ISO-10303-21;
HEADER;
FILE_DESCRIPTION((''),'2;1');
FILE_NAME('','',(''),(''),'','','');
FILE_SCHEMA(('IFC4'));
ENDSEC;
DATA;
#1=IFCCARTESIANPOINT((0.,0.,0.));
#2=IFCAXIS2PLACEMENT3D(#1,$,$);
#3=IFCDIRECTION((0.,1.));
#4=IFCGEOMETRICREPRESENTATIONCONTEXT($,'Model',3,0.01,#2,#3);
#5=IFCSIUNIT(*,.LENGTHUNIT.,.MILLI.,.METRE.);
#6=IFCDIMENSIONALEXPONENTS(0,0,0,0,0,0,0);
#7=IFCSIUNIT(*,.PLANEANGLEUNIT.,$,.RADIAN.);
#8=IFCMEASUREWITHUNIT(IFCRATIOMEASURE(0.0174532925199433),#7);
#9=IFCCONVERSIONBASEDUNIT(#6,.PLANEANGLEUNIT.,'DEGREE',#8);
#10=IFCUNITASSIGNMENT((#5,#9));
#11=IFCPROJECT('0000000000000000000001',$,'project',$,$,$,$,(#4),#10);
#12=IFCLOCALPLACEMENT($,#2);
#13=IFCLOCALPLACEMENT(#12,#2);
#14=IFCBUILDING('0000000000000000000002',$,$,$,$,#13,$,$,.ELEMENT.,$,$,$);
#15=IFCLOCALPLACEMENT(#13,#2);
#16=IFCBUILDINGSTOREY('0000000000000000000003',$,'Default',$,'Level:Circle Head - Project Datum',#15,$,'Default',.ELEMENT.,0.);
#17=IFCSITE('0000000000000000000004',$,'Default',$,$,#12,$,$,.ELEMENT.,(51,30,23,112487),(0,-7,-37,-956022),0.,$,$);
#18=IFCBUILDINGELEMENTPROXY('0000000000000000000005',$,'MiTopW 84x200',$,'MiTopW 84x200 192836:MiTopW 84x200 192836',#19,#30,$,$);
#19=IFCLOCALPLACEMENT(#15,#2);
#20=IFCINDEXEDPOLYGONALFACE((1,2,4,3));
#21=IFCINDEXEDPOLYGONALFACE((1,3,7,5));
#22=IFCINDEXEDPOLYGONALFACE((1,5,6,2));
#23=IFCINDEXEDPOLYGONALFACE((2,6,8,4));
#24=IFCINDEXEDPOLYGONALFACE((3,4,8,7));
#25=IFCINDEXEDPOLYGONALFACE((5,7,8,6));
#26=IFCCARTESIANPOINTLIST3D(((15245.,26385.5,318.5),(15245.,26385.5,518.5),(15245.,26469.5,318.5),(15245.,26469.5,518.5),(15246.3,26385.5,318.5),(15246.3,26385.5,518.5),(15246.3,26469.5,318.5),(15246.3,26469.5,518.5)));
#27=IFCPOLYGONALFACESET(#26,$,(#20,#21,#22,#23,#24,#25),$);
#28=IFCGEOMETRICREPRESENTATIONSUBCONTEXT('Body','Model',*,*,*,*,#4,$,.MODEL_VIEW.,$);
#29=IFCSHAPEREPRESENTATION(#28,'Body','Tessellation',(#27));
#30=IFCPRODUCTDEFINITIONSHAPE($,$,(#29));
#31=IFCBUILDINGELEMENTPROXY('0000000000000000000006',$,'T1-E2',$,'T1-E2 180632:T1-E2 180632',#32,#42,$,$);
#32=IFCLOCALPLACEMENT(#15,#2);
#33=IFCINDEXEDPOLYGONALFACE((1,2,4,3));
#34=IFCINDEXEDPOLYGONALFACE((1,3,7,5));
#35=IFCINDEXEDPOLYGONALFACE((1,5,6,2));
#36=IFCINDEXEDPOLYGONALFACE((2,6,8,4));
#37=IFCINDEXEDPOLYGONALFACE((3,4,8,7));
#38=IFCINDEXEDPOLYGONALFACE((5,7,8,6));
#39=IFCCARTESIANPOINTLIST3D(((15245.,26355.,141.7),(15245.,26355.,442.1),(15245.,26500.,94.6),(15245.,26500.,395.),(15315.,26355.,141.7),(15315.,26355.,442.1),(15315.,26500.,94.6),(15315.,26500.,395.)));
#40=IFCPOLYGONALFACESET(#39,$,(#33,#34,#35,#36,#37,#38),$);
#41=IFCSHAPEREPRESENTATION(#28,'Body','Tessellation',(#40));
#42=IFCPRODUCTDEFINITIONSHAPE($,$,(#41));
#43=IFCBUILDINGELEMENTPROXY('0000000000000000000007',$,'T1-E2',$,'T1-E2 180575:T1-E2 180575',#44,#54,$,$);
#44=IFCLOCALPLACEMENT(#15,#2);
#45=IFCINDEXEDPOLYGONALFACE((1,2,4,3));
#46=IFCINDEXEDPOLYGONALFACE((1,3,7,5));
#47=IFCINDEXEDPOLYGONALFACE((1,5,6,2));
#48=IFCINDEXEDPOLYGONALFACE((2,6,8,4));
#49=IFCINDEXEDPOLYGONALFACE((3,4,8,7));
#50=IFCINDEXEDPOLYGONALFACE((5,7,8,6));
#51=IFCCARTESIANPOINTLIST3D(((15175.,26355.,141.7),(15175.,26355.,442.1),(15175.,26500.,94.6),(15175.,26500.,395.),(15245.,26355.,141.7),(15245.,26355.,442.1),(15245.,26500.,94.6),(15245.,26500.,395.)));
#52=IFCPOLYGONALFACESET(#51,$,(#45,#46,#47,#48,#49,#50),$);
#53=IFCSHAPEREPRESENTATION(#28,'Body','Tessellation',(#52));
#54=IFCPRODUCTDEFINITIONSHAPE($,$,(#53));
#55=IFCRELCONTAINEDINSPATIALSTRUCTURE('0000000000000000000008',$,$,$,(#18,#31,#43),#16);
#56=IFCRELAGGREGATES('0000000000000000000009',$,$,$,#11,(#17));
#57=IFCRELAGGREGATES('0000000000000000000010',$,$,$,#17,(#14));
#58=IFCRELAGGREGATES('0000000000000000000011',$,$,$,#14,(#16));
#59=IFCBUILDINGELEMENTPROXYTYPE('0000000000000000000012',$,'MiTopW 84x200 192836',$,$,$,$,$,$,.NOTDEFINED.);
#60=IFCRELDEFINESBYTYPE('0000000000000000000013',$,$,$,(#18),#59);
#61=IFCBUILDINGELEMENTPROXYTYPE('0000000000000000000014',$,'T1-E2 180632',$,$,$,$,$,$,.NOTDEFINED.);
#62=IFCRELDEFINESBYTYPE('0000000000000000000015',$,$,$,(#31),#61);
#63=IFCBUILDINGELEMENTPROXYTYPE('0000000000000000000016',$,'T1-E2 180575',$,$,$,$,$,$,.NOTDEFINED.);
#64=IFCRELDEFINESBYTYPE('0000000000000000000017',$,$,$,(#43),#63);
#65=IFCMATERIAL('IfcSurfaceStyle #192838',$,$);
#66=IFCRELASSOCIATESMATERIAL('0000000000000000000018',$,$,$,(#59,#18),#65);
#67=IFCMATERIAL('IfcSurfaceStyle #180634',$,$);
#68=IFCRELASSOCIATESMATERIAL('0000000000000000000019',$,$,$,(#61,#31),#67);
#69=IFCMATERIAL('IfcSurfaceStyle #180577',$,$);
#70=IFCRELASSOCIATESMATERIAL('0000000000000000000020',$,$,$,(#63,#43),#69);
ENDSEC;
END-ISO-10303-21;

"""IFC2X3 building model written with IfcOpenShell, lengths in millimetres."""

from ifc_helpers import new_model, entity, si_unit, converted_unit, direction, frame, frame_2d, origin, place, context, subcontext, project, spatial, polyline, rectangle, outline, extrude, source, transform, mapped, material, type_object, type_shapes, element, save


model = new_model("IFC2X3")

# Units and contexts
model_context = context("Model", 3, precision=0.01, world=origin(), true_north=direction((0.0, 1.0)))
body_context = subcontext(model_context, "Body", "Model", "MODEL_VIEW")
ifc_project = project(units=[si_unit("LENGTHUNIT", "METRE", prefix="MILLI"), converted_unit("PLANEANGLEUNIT", "DEGREE", entity("IfcRatioMeasure", 0.0174532925199433), si_unit("PLANEANGLEUNIT", "RADIAN"), dimensions=[0, 0, 0, 0, 0, 0, 0])], contexts=[model_context])

# Site, building, storey
site_placement = place(None, origin())
site = spatial("IfcSite", under=ifc_project, at=site_placement, Name="Default", CompositionType="ELEMENT", RefLatitude=(51, 30, 23, 112487), RefLongitude=(0, -7, -37, -956022), RefElevation=0.0)
building_placement = place(site_placement, origin())
building = spatial("IfcBuilding", under=site, at=building_placement, CompositionType="ELEMENT")
storey_placement = place(building_placement, origin())
storey = spatial("IfcBuildingStorey", under=building, at=storey_placement, Name="Default", ObjectType="Level:Circle Head - Project Datum", LongName="Default", CompositionType="ELEMENT", Elevation=0.0)

# Building element proxies
ifc_material_1 = material(Name="IfcSurfaceStyle #192838")
building_element_proxy_type_1 = type_object("IfcBuildingElementProxyType", Name="MiTopW 84x200 192836", PredefinedType="NOTDEFINED", material=ifc_material_1)
shared_shape_1 = source(origin(), body_context, "Body", "SweptSolid", [
    extrude(rectangle(XDim=200.0, YDim=84.0, at=frame_2d((0.0, 0.0), x_axis=(1.0, 0.0))), frame((100.0, 42.0, 0.0), z_axis=(0.0, 0.0, 1.0), x_axis=(-1.0, 0.0, 0.0)), (0.0, 0.0, 1.0), 1.3),
])
type_shapes(building_element_proxy_type_1, [shared_shape_1])
proxy_1_placement = place(building_placement, frame((15246.3, 26469.5, 518.5), z_axis=(-1.0, 0.0, 0.0), x_axis=(0.0, 0.0, -1.0)))
element("IfcBuildingElementProxy", 1, at=proxy_1_placement, inside=storey, type_object=building_element_proxy_type_1, material=ifc_material_1, Name="MiTopW 84x200", ObjectType="MiTopW 84x200 192836:MiTopW 84x200 192836", context=body_context, shape_type="MappedRepresentation", body=[
    mapped(shared_shape_1, transform((0.0, 0.0, 0.0), scale=1.0)),
])
ifc_material_2 = material(Name="IfcSurfaceStyle #180634")
building_element_proxy_type_2 = type_object("IfcBuildingElementProxyType", Name="T1-E2 180632", PredefinedType="NOTDEFINED", material=ifc_material_2)
shared_shape_2 = source(origin(), body_context, "Body", "SweptSolid", [
    extrude(outline(polyline([(-126.6, -72.5), (173.8, -72.5), (126.6, 72.5), (-173.8, 72.5), (-126.6, -72.5)])), frame((173.8, 72.5, 0.0), z_axis=(0.0, 0.0, 1.0), x_axis=(-1.0, 0.0, 0.0)), (0.0, 0.0, 1.0), 70.0),
])
type_shapes(building_element_proxy_type_2, [shared_shape_2])
proxy_2_placement = place(building_placement, frame((15315.0, 26500.0, 442.1), z_axis=(-1.0, 0.0, 0.0), x_axis=(0.0, 0.0, -1.0)))
element("IfcBuildingElementProxy", 2, at=proxy_2_placement, inside=storey, type_object=building_element_proxy_type_2, material=ifc_material_2, Name="T1-E2", ObjectType="T1-E2 180632:T1-E2 180632", context=body_context, shape_type="MappedRepresentation", body=[
    mapped(shared_shape_2, transform((0.0, 0.0, 0.0), scale=1.0)),
])
ifc_material_3 = material(Name="IfcSurfaceStyle #180577")
building_element_proxy_type_3 = type_object("IfcBuildingElementProxyType", Name="T1-E2 180575", PredefinedType="NOTDEFINED", material=ifc_material_3)
shared_shape_3 = source(origin(), body_context, "Body", "SweptSolid", [
    extrude(outline(polyline([(-126.6, -72.5), (173.8, -72.5), (126.6, 72.5), (-173.8, 72.5), (-126.6, -72.5)])), frame((173.8, 72.5, 0.0), z_axis=(0.0, 0.0, 1.0), x_axis=(-1.0, 0.0, 0.0)), (0.0, 0.0, 1.0), 70.0),
])
type_shapes(building_element_proxy_type_3, [shared_shape_3])
proxy_3_placement = place(building_placement, frame((15245.0, 26500.0, 442.1), z_axis=(-1.0, 0.0, 0.0), x_axis=(0.0, 0.0, -1.0)))
element("IfcBuildingElementProxy", 3, at=proxy_3_placement, inside=storey, type_object=building_element_proxy_type_3, material=ifc_material_3, Name="T1-E2", ObjectType="T1-E2 180575:T1-E2 180575", context=body_context, shape_type="MappedRepresentation", body=[
    mapped(shared_shape_3, transform((0.0, 0.0, 0.0), scale=1.0)),
])

save(model, "model.ifc")
